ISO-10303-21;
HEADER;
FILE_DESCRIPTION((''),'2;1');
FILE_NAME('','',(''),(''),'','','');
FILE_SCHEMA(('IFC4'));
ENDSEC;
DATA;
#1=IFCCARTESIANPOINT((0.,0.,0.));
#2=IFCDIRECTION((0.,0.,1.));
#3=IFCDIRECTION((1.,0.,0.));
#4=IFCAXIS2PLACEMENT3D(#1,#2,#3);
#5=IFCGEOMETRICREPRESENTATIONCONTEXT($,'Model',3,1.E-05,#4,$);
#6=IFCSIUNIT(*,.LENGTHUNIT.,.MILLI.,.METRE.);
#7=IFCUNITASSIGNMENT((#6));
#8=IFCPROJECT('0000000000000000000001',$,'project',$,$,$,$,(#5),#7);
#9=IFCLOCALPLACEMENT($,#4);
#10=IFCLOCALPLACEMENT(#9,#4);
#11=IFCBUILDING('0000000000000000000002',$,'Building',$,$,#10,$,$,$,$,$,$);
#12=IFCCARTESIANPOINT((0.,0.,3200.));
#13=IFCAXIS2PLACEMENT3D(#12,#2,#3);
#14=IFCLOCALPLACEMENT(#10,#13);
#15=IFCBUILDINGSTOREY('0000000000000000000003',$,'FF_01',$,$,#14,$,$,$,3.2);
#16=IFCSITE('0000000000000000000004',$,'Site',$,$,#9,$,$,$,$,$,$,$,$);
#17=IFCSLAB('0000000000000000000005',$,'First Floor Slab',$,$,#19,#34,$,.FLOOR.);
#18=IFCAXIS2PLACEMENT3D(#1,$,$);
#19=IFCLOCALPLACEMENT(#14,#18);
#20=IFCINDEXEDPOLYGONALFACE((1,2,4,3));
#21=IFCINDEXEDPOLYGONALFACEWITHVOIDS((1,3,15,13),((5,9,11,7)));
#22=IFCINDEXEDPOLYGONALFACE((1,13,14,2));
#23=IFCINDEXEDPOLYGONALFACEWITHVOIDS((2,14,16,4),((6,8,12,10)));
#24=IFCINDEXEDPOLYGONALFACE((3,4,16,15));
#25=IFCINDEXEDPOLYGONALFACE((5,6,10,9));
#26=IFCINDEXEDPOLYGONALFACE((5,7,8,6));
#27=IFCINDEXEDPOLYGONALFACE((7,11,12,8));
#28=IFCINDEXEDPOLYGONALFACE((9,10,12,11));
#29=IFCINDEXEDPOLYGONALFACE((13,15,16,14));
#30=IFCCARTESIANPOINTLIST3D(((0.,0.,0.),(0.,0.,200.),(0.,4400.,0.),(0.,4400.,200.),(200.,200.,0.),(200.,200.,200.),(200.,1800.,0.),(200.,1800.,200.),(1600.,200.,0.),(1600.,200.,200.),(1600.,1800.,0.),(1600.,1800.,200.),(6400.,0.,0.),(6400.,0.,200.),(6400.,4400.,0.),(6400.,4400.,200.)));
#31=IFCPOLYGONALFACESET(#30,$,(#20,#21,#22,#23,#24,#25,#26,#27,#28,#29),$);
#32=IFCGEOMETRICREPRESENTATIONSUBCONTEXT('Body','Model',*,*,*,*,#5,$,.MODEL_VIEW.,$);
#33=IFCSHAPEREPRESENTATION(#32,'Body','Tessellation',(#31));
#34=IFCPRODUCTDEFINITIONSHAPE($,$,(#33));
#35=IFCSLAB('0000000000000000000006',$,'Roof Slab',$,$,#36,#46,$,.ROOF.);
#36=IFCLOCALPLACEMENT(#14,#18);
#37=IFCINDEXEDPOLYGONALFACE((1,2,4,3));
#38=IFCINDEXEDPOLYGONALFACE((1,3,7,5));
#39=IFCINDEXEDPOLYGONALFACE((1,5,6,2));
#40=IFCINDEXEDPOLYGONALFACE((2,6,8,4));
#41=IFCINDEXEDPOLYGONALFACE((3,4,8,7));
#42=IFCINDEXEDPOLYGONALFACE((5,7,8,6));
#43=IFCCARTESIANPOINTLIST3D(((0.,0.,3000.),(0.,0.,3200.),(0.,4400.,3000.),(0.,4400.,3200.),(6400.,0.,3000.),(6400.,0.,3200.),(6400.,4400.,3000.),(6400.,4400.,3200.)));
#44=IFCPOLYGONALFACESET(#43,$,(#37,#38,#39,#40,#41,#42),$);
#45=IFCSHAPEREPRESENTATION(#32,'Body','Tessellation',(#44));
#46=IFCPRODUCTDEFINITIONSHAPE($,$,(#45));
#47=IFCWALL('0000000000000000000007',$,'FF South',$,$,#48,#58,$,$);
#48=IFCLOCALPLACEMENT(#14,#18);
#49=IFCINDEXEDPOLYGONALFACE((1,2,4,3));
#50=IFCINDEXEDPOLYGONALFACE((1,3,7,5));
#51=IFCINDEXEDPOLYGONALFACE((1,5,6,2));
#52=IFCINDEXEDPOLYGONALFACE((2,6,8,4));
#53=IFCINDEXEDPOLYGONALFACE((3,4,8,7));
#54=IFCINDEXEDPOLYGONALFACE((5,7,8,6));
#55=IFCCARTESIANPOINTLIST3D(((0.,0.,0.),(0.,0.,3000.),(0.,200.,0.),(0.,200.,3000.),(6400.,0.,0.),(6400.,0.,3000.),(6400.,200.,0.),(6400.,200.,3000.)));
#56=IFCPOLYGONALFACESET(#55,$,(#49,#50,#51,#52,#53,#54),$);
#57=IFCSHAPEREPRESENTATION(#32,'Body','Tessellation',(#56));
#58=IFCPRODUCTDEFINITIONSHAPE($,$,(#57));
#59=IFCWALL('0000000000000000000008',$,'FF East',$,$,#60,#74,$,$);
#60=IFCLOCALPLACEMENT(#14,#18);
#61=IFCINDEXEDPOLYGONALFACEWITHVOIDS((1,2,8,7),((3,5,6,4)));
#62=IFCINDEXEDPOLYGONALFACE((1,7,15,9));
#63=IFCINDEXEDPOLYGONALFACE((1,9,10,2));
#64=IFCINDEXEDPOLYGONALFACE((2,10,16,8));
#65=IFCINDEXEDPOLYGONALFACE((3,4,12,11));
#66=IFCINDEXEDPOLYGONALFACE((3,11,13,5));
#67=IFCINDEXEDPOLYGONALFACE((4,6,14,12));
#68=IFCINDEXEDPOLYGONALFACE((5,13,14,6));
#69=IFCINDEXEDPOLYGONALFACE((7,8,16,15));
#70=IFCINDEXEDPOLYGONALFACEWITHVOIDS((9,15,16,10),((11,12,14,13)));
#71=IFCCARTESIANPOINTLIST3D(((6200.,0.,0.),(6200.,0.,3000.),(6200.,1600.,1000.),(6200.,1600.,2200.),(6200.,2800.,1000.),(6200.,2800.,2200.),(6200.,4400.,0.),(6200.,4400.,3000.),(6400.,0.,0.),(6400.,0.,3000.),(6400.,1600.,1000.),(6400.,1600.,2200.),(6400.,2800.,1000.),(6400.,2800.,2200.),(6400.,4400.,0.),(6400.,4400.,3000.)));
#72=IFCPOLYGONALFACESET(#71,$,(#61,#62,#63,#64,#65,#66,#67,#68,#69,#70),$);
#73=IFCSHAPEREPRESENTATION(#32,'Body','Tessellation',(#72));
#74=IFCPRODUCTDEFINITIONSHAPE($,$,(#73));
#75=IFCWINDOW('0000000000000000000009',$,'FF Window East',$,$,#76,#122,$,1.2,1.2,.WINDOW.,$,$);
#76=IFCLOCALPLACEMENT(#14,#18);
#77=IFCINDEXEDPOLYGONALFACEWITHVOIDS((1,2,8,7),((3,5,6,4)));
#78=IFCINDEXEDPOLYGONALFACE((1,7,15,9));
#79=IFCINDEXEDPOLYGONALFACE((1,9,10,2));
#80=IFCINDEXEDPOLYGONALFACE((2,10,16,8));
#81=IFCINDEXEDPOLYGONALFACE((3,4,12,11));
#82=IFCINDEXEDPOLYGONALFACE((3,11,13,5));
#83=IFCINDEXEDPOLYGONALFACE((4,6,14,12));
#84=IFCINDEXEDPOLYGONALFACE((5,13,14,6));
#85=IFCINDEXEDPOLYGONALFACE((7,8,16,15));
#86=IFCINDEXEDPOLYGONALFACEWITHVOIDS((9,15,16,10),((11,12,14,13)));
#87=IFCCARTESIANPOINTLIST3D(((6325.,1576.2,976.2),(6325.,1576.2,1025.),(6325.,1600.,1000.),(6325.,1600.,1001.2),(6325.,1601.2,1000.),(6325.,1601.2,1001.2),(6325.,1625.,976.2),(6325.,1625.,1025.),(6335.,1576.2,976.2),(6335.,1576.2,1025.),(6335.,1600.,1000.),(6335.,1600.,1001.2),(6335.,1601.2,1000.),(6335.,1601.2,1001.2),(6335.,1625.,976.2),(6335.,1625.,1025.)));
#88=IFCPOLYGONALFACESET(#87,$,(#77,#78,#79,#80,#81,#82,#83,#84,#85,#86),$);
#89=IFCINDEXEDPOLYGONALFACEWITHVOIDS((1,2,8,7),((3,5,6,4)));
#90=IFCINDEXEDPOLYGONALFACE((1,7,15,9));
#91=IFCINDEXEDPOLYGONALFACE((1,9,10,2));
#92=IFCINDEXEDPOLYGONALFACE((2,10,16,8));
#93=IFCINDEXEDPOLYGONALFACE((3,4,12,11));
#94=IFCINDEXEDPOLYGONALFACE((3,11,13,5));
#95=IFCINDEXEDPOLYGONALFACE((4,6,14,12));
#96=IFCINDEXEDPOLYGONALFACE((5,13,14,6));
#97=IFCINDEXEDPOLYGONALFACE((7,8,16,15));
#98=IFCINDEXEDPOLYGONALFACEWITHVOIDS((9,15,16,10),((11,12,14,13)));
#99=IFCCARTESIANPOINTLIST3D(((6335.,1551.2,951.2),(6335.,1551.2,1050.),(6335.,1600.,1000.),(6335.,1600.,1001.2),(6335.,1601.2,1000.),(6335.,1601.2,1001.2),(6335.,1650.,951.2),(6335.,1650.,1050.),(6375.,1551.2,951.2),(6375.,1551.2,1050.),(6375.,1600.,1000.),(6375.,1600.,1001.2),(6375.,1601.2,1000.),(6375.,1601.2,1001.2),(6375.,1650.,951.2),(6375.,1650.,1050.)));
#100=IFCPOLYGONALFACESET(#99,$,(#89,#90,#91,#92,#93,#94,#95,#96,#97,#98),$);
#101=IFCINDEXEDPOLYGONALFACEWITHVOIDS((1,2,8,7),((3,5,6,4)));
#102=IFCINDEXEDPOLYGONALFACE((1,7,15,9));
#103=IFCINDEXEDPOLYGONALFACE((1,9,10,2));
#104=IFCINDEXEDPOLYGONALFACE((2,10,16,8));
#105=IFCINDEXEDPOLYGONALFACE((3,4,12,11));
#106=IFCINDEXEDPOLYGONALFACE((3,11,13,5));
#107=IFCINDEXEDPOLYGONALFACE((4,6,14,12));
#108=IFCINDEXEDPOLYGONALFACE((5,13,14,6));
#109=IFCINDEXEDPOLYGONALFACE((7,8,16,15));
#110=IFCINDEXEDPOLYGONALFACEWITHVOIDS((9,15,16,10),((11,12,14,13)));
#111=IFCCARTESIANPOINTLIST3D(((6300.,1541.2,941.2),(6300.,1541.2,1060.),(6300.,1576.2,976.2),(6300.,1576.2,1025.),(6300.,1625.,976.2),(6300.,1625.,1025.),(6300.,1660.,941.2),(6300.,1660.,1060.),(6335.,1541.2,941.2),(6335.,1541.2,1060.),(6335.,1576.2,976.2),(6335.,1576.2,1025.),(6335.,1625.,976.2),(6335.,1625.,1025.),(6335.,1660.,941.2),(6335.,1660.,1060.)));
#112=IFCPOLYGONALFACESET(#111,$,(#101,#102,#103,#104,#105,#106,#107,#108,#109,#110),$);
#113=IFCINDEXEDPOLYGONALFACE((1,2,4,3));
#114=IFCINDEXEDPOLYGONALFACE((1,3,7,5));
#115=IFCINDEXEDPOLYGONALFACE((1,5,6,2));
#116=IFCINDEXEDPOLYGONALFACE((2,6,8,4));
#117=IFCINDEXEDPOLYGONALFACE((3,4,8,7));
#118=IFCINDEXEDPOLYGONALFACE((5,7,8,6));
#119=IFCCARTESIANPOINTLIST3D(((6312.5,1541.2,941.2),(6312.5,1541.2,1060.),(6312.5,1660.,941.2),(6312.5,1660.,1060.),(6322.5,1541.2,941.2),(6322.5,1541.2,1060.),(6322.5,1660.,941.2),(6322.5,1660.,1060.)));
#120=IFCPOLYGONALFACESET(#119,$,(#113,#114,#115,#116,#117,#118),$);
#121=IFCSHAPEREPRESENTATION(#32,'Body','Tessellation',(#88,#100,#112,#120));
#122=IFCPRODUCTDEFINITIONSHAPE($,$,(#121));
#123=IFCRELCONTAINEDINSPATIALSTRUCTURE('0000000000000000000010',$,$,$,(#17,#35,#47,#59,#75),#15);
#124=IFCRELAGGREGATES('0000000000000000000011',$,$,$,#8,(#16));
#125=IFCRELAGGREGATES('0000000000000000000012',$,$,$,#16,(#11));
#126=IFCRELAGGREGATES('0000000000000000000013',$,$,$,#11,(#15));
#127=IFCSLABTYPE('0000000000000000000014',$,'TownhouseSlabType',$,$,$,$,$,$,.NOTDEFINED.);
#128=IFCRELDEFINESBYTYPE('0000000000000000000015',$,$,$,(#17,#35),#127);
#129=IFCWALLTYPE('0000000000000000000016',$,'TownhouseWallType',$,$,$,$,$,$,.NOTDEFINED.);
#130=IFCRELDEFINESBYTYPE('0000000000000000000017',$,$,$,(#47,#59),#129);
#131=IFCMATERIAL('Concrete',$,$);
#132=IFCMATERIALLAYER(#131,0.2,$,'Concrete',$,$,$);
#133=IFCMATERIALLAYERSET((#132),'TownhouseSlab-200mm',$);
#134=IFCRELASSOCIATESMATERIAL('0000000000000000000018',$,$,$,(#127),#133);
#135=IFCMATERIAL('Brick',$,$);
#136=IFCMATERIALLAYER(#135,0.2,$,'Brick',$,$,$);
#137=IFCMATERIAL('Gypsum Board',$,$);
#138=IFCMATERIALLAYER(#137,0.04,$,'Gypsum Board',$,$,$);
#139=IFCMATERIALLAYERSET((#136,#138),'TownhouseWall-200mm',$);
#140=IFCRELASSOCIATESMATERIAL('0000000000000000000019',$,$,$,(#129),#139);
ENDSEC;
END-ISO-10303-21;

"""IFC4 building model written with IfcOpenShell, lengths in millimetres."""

from ifc_helpers import new_model, si_unit, frame, origin_with_axes, place, context, subcontext, project, spatial, line, indexed_curve, outline, extrude, material, layer, layer_set, type_object, element, fill, save


model = new_model("IFC4")

# Units and contexts
model_context = context("Model", 3, precision=1e-05, world=origin_with_axes())
body_context = subcontext(model_context, "Body", "Model", "MODEL_VIEW")
ifc_project = project(units=[si_unit("LENGTHUNIT", "METRE", prefix="MILLI")], contexts=[model_context])

# Site, building, storey
site_placement = place(None, origin_with_axes())
site = spatial("IfcSite", under=ifc_project, at=site_placement, Name="Site")
building_placement = place(site_placement, origin_with_axes())
building = spatial("IfcBuilding", under=site, at=building_placement, Name="Building")
storey_placement = place(building_placement, frame((0.0, 0.0, 3200.0), z_axis=(0.0, 0.0, 1.0), x_axis=(1.0, 0.0, 0.0)))
storey = spatial("IfcBuildingStorey", under=building, at=storey_placement, Name="FF_01", Elevation=3.2)

# Slab, opening
ifc_material_1 = material(Name="Concrete")
ifc_layer_1 = layer(ifc_material_1, 0.2, Name="Concrete")
ifc_layer_set_1 = layer_set([ifc_layer_1], Name="TownhouseSlab-200mm")
slab_type = type_object("IfcSlabType", Name="TownhouseSlabType", PredefinedType="NOTDEFINED", material=ifc_layer_set_1)
slab_1_placement = place(storey_placement, origin_with_axes())
slab_1 = element("IfcSlab", 1, at=slab_1_placement, inside=storey, type_object=slab_type, Name="First Floor Slab", PredefinedType="FLOOR", context=body_context, shape_type="SweptSolid", body=[
    extrude(outline(indexed_curve([(0.0, 0.0), (6400.0, 0.0), (6400.0, 4400.0), (0.0, 4400.0), (0.0, 0.0)])), None, (0.0, 0.0, 1.0), 200.0),
])
opening_1_placement = place(slab_1_placement, origin_with_axes())
element("IfcOpeningElement", 2, at=opening_1_placement, cuts=slab_1, context=body_context, shape_type="SweptSolid", body=[
    extrude(outline(indexed_curve([(200.0, 200.0), (1600.0, 200.0), (1600.0, 1800.0), (200.0, 1800.0), (200.0, 200.0)])), None, (0.0, 0.0, 1.0), 250.0),
])

# Slab
slab_2_placement = place(storey_placement, frame((0.0, 0.0, 3000.0), z_axis=(0.0, 0.0, 1.0), x_axis=(1.0, 0.0, 0.0)))
element("IfcSlab", 3, at=slab_2_placement, inside=storey, type_object=slab_type, Name="Roof Slab", PredefinedType="ROOF", context=body_context, shape_type="SweptSolid", body=[
    extrude(outline(indexed_curve([(0.0, 0.0), (6400.0, 0.0), (6400.0, 4400.0), (0.0, 4400.0), (0.0, 0.0)])), None, (0.0, 0.0, 1.0), 200.0),
])

# Wall
ifc_material_2 = material(Name="Brick")
ifc_layer_2 = layer(ifc_material_2, 0.2, Name="Brick")
ifc_material_3 = material(Name="Gypsum Board")
ifc_layer_3 = layer(ifc_material_3, 0.04, Name="Gypsum Board")
ifc_layer_set_2 = layer_set([ifc_layer_2, ifc_layer_3], Name="TownhouseWall-200mm")
wall_type = type_object("IfcWallType", Name="TownhouseWallType", PredefinedType="NOTDEFINED", material=ifc_layer_set_2)
wall_1_placement = place(storey_placement, origin_with_axes())
element("IfcWall", 4, at=wall_1_placement, inside=storey, type_object=wall_type, Name="FF South", context=body_context, shape_type="SweptSolid", body=[
    extrude(outline(indexed_curve([(0.0, 0.0), (0.0, 200.0), (6400.0, 200.0), (6400.0, 0.0), (0.0, 0.0)], self_intersect=False)), origin_with_axes(), (0.0, 0.0, 1.0), 3000.0),
])

# Wall, opening, window
wall_2_placement = place(storey_placement, frame((6400.0, 0.0, 0.0), z_axis=(0.0, 0.0, 1.0), x_axis=(0.0, 1.0, 0.0)))
wall_2 = element("IfcWall", 5, at=wall_2_placement, inside=storey, type_object=wall_type, Name="FF East", context=body_context, shape_type="SweptSolid", body=[
    extrude(outline(indexed_curve([(0.0, 0.0), (0.0, 200.0), (4400.0, 200.0), (4400.0, 0.0), (0.0, 0.0)], self_intersect=False)), origin_with_axes(), (0.0, 0.0, 1.0), 3000.0),
])
opening_2_placement = place(wall_2_placement, frame((1600.0, -25.0, 1000.0), z_axis=(0.0, 0.0, 1.0), x_axis=(1.0, 0.0, 0.0)))
opening_2 = element("IfcOpeningElement", 6, at=opening_2_placement, cuts=wall_2, context=body_context, shape_type="SweptSolid", body=[
    extrude(outline(indexed_curve([(0.0, 0.0), (0.0, 250.0), (1200.0, 250.0), (1200.0, 0.0), (0.0, 0.0)], self_intersect=False)), origin_with_axes(), (0.0, 0.0, 1.0), 1200.0),
])
window_1_placement = place(storey_placement, frame((6425.0, 1600.0, 1000.0), z_axis=(0.0, 0.0, 1.0), x_axis=(0.0, 1.0, 0.0)))
window_1 = element("IfcWindow", 7, at=window_1_placement, inside=storey, Name="FF Window East", OverallHeight=1.2, OverallWidth=1.2, PredefinedType="WINDOW", context=body_context, shape_type="SweptSolid", body=[
    extrude(outline(indexed_curve([(0.0, 0.0), (1.2, 0.0), (1.2, 1.2), (0.0, 1.2)], segments=[line(1, 2, 3, 4, 1)]), holes=[indexed_curve([(25.0, 25.0), (-23.8, 25.0), (-23.8, -23.8), (25.0, -23.8)], segments=[line(1, 2, 3, 4, 1)])]), frame((0.0, 90.0, 0.0), z_axis=(0.0, -1.0, 0.0), x_axis=(1.0, 0.0, 0.0)), (0.0, 0.0, -1.0), 10.0),
    extrude(outline(indexed_curve([(0.0, 0.0), (1.2, 0.0), (1.2, 1.2), (0.0, 1.2)], segments=[line(1, 2, 3, 4, 1)]), holes=[indexed_curve([(50.0, 50.0), (-48.8, 50.0), (-48.8, -48.8), (50.0, -48.8)], segments=[line(1, 2, 3, 4, 1)])]), frame((0.0, 50.0, 0.0), z_axis=(0.0, -1.0, 0.0), x_axis=(1.0, 0.0, 0.0)), (0.0, 0.0, -1.0), 40.0),
    extrude(outline(indexed_curve([(0.0, 0.0), (-48.8, 0.0), (-48.8, -48.8), (0.0, -48.8)], segments=[line(1, 2, 3, 4, 1)]), holes=[indexed_curve([(35.0, 35.0), (-83.8, 35.0), (-83.8, -83.8), (35.0, -83.8)], segments=[line(1, 2, 3, 4, 1)])]), frame((25.0, 90.0, 25.0), z_axis=(0.0, -1.0, 0.0), x_axis=(1.0, 0.0, 0.0)), (0.0, 0.0, -1.0), 35.0),
    extrude(outline(indexed_curve([(35.0, 35.0), (-83.8, 35.0), (-83.8, -83.8), (35.0, -83.8)], segments=[line(1, 2, 3, 4, 1)])), frame((25.0, 102.5, 25.0), z_axis=(0.0, -1.0, 0.0), x_axis=(1.0, 0.0, 0.0)), (0.0, 0.0, -1.0), 10.0),
])
fill(opening_2, window_1)

save(model, "model.ifc")
